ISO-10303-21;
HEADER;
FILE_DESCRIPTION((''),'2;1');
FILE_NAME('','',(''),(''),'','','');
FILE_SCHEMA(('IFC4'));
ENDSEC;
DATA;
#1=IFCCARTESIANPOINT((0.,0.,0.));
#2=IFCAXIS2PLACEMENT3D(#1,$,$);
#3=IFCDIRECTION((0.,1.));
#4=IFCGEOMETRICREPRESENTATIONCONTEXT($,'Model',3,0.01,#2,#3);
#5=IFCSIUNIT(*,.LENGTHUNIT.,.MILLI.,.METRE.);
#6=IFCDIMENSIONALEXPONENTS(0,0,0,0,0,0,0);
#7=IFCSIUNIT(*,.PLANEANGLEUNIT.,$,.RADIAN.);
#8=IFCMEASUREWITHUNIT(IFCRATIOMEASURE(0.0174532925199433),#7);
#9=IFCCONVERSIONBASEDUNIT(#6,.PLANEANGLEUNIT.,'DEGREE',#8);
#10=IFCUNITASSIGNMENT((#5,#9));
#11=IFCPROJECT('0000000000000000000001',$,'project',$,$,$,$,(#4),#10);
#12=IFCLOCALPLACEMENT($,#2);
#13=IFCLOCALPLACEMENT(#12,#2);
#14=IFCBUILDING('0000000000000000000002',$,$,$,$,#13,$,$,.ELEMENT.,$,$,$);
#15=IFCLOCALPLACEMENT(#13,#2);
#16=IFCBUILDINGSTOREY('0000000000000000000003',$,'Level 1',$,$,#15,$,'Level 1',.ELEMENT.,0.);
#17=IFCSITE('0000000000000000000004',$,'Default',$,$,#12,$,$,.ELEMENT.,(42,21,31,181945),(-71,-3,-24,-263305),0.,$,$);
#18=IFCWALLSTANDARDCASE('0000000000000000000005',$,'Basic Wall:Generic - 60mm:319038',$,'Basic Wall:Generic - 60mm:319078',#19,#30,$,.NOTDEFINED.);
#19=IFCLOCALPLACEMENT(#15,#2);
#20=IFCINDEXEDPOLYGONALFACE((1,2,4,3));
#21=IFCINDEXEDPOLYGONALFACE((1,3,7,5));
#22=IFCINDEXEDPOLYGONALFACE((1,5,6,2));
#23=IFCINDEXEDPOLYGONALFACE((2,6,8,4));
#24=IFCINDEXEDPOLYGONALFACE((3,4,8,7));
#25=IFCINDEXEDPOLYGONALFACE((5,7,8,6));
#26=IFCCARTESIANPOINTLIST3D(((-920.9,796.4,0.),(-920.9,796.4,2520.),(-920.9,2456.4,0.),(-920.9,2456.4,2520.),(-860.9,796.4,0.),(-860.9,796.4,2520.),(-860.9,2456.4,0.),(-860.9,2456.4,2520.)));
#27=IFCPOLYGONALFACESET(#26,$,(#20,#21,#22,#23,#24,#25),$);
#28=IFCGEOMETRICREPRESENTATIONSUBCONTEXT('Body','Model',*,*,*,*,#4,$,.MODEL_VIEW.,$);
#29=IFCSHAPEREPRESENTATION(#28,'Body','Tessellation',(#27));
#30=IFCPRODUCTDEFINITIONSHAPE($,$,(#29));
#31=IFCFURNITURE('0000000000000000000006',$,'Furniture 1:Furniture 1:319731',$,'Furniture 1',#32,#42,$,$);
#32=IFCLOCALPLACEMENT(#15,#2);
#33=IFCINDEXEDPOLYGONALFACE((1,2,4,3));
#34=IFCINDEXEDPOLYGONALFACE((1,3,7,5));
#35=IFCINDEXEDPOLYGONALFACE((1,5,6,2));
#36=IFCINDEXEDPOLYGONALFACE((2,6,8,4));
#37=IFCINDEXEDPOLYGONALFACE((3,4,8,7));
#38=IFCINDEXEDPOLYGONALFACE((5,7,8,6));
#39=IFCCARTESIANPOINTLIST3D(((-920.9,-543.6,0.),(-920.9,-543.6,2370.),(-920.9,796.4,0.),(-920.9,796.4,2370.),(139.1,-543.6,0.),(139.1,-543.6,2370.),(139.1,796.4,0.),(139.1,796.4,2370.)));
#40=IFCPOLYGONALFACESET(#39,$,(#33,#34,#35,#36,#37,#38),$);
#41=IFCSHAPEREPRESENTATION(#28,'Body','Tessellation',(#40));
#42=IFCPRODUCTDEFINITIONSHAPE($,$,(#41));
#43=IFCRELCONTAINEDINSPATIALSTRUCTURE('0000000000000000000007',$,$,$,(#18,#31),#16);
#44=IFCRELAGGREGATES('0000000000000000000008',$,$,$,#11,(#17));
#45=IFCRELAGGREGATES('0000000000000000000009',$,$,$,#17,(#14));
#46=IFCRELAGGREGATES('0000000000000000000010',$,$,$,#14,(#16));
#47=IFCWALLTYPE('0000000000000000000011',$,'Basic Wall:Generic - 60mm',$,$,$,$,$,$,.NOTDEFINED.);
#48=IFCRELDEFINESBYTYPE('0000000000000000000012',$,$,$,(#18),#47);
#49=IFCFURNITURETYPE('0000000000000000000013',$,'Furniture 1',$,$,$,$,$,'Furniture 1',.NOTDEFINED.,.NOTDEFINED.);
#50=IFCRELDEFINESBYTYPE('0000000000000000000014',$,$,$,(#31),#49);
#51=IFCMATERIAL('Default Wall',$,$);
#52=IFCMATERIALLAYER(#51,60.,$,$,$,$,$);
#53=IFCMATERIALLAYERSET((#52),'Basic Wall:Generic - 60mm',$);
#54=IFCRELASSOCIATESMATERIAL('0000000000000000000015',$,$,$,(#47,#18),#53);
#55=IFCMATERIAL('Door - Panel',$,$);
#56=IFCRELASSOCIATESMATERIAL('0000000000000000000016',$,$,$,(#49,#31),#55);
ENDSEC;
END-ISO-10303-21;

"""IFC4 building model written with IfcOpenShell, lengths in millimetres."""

from ifc_helpers import new_model, entity, si_unit, converted_unit, direction, frame, frame_2d, origin, origin_2d_with_axis, place, context, subcontext, project, spatial, rectangle, extrude, source, transform, mapped, material, layer, layer_set, layer_usage, type_object, type_shapes, element, save


model = new_model("IFC4")

# Units and contexts
model_context = context("Model", 3, precision=0.01, world=origin(), true_north=direction((0.0, 1.0)))
body_context = subcontext(model_context, "Body", "Model", "MODEL_VIEW")
ifc_project = project(units=[si_unit("LENGTHUNIT", "METRE", prefix="MILLI"), converted_unit("PLANEANGLEUNIT", "DEGREE", entity("IfcRatioMeasure", 0.0174532925199433), si_unit("PLANEANGLEUNIT", "RADIAN"), dimensions=[0, 0, 0, 0, 0, 0, 0])], contexts=[model_context])

# Site, building, storey
site_placement = place(None, origin())
site = spatial("IfcSite", under=ifc_project, at=site_placement, Name="Default", CompositionType="ELEMENT", RefLatitude=(42, 21, 31, 181945), RefLongitude=(-71, -3, -24, -263305), RefElevation=0.0)
building_placement = place(site_placement, origin())
building = spatial("IfcBuilding", under=site, at=building_placement, CompositionType="ELEMENT")
storey_placement = place(building_placement, origin())
storey = spatial("IfcBuildingStorey", under=building, at=storey_placement, Name="Level 1", LongName="Level 1", CompositionType="ELEMENT", Elevation=0.0)

# Shared definitions
ifc_material_1 = material(Name="Default Wall")

# Shared definitions
ifc_material_2 = material(Name="Door - Panel")

# Wall
ifc_layer_1 = layer(ifc_material_1, 60.0)
ifc_layer_set_1 = layer_set([ifc_layer_1], Name="Basic Wall:Generic - 60mm")
ifc_layer_usage_1 = layer_usage(ifc_layer_set_1, "AXIS2", "NEGATIVE", 30.0)
wall_type_1 = type_object("IfcWallType", Name="Basic Wall:Generic - 60mm", PredefinedType="NOTDEFINED", material=ifc_layer_set_1)
wall_1_placement = place(storey_placement, frame((-890.9, 2456.4, 0.0), z_axis=(0.0, 0.0, 1.0), x_axis=(0.0, -1.0, 0.0)))
element("IfcWallStandardCase", 1, at=wall_1_placement, inside=storey, type_object=wall_type_1, material=ifc_layer_usage_1, Name="Basic Wall:Generic - 60mm:319038", ObjectType="Basic Wall:Generic - 60mm:319078", PredefinedType="NOTDEFINED", context=body_context, shape_type="SweptSolid", body=[
    extrude(rectangle(XDim=1660.0, YDim=60.0, at=frame_2d((830.0, 0.0), x_axis=(-1.0, 0.0))), origin(), (0.0, 0.0, 1.0), 2520.0),
])

# Furniture
furniture_type = type_object("IfcFurnitureType", Name="Furniture 1", ElementType="Furniture 1", AssemblyPlace="NOTDEFINED", PredefinedType="NOTDEFINED", material=ifc_material_2)
shared_shape_1 = source(origin(), body_context, "Body", "SweptSolid", [
    extrude(rectangle(XDim=1340.0, YDim=1060.0, at=origin_2d_with_axis()), frame((-390.9, 126.4, 0.0), z_axis=(0.0, 0.0, 1.0), x_axis=(0.0, 1.0, 0.0)), (0.0, 0.0, 1.0), 2370.0),
])
type_shapes(furniture_type, [shared_shape_1])
furniture_placement = place(storey_placement, origin())
element("IfcFurniture", 2, at=furniture_placement, inside=storey, type_object=furniture_type, material=ifc_material_2, Name="Furniture 1:Furniture 1:319731", ObjectType="Furniture 1", context=body_context, shape_type="MappedRepresentation", body=[
    mapped(shared_shape_1, transform((0.0, 0.0, 0.0), scale=1.0)),
])

save(model, "model.ifc")
